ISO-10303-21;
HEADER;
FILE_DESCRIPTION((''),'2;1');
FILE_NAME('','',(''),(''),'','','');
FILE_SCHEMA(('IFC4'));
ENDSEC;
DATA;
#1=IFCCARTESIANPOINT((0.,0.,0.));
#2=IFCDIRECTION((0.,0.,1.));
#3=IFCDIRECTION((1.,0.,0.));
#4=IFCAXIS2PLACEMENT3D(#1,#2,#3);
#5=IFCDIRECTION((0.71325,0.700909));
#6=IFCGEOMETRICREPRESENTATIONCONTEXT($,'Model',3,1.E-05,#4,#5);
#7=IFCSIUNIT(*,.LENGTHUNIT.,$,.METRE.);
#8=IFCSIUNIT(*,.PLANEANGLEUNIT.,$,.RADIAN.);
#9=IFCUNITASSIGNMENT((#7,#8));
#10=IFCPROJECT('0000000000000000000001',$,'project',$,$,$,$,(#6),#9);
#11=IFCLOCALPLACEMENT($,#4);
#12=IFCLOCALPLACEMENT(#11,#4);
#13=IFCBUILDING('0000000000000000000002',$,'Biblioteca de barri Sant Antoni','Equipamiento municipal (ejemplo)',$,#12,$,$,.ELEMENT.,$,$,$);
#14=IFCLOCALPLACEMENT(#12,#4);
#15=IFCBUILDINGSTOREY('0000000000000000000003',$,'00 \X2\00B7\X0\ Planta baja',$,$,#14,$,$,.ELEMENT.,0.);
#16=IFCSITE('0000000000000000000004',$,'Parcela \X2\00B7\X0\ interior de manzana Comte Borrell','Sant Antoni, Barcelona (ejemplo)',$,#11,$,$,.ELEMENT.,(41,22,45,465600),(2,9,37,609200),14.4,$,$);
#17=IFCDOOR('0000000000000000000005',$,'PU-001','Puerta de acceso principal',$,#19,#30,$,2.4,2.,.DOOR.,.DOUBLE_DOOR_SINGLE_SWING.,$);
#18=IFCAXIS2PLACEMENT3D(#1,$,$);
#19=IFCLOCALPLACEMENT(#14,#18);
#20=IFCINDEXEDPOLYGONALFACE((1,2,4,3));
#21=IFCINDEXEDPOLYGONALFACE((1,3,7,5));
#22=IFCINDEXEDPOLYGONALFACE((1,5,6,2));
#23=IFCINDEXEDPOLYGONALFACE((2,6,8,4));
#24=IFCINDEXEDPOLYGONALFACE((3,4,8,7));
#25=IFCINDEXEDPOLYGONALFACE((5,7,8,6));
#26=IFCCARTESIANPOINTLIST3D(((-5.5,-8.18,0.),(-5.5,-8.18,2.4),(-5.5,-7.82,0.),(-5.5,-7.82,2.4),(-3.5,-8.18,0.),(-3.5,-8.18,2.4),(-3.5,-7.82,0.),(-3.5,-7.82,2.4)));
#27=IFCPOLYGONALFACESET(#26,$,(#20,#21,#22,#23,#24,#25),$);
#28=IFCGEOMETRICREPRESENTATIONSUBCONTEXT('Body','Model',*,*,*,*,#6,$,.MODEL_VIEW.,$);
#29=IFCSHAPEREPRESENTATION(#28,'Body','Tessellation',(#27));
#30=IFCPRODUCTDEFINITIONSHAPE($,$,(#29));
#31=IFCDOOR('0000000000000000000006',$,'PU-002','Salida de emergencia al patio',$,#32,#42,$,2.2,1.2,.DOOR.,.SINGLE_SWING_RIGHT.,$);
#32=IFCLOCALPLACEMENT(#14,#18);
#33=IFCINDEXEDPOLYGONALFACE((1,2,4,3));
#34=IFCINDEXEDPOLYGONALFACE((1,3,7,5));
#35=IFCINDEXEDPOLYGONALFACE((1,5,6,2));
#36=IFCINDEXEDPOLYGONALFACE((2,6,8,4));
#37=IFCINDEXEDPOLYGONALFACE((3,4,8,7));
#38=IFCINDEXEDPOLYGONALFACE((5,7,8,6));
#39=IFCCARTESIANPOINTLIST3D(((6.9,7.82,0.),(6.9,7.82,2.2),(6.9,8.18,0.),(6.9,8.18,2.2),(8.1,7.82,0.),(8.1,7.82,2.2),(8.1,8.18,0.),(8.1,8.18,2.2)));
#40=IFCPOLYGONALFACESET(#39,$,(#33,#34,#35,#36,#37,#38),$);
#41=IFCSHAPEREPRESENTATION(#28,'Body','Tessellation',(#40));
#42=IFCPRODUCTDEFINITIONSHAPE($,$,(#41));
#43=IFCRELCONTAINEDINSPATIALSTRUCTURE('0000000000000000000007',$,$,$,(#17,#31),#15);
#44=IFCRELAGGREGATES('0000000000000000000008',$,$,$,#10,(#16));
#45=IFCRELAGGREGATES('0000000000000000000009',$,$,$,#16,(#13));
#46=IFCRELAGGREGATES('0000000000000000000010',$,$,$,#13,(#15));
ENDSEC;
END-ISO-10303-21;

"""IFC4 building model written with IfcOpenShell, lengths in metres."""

from ifc_helpers import new_model, si_unit, direction, frame, origin_with_axes, origin_2d, place, context, subcontext, project, spatial, rectangle, extrude, element, save


model = new_model("IFC4")

# Units and contexts
model_context = context("Model", 3, precision=1e-05, world=origin_with_axes(), true_north=direction((0.71325, 0.700909)))
body_context = subcontext(model_context, "Body", "Model", "MODEL_VIEW")
ifc_project = project(units=[si_unit("LENGTHUNIT", "METRE"), si_unit("PLANEANGLEUNIT", "RADIAN")], contexts=[model_context])

# Site, building, storey
site_placement = place(None, origin_with_axes())
site = spatial("IfcSite", under=ifc_project, at=site_placement, Name="Parcela · interior de manzana Comte Borrell", Description="Sant Antoni, Barcelona (ejemplo)", CompositionType="ELEMENT", RefLatitude=(41, 22, 45, 465600), RefLongitude=(2, 9, 37, 609200), RefElevation=14.4)
building_placement = place(site_placement, origin_with_axes())
building = spatial("IfcBuilding", under=site, at=building_placement, Name="Biblioteca de barri Sant Antoni", Description="Equipamiento municipal (ejemplo)", CompositionType="ELEMENT")
storey_placement = place(building_placement, origin_with_axes())
storey = spatial("IfcBuildingStorey", under=building, at=storey_placement, Name="00 · Planta baja", CompositionType="ELEMENT", Elevation=0.0)

# Doors
door_1_placement = place(storey_placement, frame((-4.5, -8.0, 0.0), z_axis=(0.0, 0.0, 1.0), x_axis=(1.0, 0.0, 0.0)))
element("IfcDoor", 1, at=door_1_placement, inside=storey, Name="PU-001", Description="Puerta de acceso principal", OperationType="DOUBLE_DOOR_SINGLE_SWING", OverallHeight=2.4, OverallWidth=2.0, PredefinedType="DOOR", context=body_context, shape_type="SweptSolid", body=[
    extrude(rectangle(XDim=2.0, YDim=0.36, at=origin_2d()), origin_with_axes(), (0.0, 0.0, 1.0), 2.4),
])
door_2_placement = place(storey_placement, frame((7.5, 8.0, 0.0), z_axis=(0.0, 0.0, 1.0), x_axis=(1.0, 0.0, 0.0)))
element("IfcDoor", 2, at=door_2_placement, inside=storey, Name="PU-002", Description="Salida de emergencia al patio", OperationType="SINGLE_SWING_RIGHT", OverallHeight=2.2, OverallWidth=1.2, PredefinedType="DOOR", context=body_context, shape_type="SweptSolid", body=[
    extrude(rectangle(XDim=1.2, YDim=0.36, at=origin_2d()), origin_with_axes(), (0.0, 0.0, 1.0), 2.2),
])

save(model, "model.ifc")
